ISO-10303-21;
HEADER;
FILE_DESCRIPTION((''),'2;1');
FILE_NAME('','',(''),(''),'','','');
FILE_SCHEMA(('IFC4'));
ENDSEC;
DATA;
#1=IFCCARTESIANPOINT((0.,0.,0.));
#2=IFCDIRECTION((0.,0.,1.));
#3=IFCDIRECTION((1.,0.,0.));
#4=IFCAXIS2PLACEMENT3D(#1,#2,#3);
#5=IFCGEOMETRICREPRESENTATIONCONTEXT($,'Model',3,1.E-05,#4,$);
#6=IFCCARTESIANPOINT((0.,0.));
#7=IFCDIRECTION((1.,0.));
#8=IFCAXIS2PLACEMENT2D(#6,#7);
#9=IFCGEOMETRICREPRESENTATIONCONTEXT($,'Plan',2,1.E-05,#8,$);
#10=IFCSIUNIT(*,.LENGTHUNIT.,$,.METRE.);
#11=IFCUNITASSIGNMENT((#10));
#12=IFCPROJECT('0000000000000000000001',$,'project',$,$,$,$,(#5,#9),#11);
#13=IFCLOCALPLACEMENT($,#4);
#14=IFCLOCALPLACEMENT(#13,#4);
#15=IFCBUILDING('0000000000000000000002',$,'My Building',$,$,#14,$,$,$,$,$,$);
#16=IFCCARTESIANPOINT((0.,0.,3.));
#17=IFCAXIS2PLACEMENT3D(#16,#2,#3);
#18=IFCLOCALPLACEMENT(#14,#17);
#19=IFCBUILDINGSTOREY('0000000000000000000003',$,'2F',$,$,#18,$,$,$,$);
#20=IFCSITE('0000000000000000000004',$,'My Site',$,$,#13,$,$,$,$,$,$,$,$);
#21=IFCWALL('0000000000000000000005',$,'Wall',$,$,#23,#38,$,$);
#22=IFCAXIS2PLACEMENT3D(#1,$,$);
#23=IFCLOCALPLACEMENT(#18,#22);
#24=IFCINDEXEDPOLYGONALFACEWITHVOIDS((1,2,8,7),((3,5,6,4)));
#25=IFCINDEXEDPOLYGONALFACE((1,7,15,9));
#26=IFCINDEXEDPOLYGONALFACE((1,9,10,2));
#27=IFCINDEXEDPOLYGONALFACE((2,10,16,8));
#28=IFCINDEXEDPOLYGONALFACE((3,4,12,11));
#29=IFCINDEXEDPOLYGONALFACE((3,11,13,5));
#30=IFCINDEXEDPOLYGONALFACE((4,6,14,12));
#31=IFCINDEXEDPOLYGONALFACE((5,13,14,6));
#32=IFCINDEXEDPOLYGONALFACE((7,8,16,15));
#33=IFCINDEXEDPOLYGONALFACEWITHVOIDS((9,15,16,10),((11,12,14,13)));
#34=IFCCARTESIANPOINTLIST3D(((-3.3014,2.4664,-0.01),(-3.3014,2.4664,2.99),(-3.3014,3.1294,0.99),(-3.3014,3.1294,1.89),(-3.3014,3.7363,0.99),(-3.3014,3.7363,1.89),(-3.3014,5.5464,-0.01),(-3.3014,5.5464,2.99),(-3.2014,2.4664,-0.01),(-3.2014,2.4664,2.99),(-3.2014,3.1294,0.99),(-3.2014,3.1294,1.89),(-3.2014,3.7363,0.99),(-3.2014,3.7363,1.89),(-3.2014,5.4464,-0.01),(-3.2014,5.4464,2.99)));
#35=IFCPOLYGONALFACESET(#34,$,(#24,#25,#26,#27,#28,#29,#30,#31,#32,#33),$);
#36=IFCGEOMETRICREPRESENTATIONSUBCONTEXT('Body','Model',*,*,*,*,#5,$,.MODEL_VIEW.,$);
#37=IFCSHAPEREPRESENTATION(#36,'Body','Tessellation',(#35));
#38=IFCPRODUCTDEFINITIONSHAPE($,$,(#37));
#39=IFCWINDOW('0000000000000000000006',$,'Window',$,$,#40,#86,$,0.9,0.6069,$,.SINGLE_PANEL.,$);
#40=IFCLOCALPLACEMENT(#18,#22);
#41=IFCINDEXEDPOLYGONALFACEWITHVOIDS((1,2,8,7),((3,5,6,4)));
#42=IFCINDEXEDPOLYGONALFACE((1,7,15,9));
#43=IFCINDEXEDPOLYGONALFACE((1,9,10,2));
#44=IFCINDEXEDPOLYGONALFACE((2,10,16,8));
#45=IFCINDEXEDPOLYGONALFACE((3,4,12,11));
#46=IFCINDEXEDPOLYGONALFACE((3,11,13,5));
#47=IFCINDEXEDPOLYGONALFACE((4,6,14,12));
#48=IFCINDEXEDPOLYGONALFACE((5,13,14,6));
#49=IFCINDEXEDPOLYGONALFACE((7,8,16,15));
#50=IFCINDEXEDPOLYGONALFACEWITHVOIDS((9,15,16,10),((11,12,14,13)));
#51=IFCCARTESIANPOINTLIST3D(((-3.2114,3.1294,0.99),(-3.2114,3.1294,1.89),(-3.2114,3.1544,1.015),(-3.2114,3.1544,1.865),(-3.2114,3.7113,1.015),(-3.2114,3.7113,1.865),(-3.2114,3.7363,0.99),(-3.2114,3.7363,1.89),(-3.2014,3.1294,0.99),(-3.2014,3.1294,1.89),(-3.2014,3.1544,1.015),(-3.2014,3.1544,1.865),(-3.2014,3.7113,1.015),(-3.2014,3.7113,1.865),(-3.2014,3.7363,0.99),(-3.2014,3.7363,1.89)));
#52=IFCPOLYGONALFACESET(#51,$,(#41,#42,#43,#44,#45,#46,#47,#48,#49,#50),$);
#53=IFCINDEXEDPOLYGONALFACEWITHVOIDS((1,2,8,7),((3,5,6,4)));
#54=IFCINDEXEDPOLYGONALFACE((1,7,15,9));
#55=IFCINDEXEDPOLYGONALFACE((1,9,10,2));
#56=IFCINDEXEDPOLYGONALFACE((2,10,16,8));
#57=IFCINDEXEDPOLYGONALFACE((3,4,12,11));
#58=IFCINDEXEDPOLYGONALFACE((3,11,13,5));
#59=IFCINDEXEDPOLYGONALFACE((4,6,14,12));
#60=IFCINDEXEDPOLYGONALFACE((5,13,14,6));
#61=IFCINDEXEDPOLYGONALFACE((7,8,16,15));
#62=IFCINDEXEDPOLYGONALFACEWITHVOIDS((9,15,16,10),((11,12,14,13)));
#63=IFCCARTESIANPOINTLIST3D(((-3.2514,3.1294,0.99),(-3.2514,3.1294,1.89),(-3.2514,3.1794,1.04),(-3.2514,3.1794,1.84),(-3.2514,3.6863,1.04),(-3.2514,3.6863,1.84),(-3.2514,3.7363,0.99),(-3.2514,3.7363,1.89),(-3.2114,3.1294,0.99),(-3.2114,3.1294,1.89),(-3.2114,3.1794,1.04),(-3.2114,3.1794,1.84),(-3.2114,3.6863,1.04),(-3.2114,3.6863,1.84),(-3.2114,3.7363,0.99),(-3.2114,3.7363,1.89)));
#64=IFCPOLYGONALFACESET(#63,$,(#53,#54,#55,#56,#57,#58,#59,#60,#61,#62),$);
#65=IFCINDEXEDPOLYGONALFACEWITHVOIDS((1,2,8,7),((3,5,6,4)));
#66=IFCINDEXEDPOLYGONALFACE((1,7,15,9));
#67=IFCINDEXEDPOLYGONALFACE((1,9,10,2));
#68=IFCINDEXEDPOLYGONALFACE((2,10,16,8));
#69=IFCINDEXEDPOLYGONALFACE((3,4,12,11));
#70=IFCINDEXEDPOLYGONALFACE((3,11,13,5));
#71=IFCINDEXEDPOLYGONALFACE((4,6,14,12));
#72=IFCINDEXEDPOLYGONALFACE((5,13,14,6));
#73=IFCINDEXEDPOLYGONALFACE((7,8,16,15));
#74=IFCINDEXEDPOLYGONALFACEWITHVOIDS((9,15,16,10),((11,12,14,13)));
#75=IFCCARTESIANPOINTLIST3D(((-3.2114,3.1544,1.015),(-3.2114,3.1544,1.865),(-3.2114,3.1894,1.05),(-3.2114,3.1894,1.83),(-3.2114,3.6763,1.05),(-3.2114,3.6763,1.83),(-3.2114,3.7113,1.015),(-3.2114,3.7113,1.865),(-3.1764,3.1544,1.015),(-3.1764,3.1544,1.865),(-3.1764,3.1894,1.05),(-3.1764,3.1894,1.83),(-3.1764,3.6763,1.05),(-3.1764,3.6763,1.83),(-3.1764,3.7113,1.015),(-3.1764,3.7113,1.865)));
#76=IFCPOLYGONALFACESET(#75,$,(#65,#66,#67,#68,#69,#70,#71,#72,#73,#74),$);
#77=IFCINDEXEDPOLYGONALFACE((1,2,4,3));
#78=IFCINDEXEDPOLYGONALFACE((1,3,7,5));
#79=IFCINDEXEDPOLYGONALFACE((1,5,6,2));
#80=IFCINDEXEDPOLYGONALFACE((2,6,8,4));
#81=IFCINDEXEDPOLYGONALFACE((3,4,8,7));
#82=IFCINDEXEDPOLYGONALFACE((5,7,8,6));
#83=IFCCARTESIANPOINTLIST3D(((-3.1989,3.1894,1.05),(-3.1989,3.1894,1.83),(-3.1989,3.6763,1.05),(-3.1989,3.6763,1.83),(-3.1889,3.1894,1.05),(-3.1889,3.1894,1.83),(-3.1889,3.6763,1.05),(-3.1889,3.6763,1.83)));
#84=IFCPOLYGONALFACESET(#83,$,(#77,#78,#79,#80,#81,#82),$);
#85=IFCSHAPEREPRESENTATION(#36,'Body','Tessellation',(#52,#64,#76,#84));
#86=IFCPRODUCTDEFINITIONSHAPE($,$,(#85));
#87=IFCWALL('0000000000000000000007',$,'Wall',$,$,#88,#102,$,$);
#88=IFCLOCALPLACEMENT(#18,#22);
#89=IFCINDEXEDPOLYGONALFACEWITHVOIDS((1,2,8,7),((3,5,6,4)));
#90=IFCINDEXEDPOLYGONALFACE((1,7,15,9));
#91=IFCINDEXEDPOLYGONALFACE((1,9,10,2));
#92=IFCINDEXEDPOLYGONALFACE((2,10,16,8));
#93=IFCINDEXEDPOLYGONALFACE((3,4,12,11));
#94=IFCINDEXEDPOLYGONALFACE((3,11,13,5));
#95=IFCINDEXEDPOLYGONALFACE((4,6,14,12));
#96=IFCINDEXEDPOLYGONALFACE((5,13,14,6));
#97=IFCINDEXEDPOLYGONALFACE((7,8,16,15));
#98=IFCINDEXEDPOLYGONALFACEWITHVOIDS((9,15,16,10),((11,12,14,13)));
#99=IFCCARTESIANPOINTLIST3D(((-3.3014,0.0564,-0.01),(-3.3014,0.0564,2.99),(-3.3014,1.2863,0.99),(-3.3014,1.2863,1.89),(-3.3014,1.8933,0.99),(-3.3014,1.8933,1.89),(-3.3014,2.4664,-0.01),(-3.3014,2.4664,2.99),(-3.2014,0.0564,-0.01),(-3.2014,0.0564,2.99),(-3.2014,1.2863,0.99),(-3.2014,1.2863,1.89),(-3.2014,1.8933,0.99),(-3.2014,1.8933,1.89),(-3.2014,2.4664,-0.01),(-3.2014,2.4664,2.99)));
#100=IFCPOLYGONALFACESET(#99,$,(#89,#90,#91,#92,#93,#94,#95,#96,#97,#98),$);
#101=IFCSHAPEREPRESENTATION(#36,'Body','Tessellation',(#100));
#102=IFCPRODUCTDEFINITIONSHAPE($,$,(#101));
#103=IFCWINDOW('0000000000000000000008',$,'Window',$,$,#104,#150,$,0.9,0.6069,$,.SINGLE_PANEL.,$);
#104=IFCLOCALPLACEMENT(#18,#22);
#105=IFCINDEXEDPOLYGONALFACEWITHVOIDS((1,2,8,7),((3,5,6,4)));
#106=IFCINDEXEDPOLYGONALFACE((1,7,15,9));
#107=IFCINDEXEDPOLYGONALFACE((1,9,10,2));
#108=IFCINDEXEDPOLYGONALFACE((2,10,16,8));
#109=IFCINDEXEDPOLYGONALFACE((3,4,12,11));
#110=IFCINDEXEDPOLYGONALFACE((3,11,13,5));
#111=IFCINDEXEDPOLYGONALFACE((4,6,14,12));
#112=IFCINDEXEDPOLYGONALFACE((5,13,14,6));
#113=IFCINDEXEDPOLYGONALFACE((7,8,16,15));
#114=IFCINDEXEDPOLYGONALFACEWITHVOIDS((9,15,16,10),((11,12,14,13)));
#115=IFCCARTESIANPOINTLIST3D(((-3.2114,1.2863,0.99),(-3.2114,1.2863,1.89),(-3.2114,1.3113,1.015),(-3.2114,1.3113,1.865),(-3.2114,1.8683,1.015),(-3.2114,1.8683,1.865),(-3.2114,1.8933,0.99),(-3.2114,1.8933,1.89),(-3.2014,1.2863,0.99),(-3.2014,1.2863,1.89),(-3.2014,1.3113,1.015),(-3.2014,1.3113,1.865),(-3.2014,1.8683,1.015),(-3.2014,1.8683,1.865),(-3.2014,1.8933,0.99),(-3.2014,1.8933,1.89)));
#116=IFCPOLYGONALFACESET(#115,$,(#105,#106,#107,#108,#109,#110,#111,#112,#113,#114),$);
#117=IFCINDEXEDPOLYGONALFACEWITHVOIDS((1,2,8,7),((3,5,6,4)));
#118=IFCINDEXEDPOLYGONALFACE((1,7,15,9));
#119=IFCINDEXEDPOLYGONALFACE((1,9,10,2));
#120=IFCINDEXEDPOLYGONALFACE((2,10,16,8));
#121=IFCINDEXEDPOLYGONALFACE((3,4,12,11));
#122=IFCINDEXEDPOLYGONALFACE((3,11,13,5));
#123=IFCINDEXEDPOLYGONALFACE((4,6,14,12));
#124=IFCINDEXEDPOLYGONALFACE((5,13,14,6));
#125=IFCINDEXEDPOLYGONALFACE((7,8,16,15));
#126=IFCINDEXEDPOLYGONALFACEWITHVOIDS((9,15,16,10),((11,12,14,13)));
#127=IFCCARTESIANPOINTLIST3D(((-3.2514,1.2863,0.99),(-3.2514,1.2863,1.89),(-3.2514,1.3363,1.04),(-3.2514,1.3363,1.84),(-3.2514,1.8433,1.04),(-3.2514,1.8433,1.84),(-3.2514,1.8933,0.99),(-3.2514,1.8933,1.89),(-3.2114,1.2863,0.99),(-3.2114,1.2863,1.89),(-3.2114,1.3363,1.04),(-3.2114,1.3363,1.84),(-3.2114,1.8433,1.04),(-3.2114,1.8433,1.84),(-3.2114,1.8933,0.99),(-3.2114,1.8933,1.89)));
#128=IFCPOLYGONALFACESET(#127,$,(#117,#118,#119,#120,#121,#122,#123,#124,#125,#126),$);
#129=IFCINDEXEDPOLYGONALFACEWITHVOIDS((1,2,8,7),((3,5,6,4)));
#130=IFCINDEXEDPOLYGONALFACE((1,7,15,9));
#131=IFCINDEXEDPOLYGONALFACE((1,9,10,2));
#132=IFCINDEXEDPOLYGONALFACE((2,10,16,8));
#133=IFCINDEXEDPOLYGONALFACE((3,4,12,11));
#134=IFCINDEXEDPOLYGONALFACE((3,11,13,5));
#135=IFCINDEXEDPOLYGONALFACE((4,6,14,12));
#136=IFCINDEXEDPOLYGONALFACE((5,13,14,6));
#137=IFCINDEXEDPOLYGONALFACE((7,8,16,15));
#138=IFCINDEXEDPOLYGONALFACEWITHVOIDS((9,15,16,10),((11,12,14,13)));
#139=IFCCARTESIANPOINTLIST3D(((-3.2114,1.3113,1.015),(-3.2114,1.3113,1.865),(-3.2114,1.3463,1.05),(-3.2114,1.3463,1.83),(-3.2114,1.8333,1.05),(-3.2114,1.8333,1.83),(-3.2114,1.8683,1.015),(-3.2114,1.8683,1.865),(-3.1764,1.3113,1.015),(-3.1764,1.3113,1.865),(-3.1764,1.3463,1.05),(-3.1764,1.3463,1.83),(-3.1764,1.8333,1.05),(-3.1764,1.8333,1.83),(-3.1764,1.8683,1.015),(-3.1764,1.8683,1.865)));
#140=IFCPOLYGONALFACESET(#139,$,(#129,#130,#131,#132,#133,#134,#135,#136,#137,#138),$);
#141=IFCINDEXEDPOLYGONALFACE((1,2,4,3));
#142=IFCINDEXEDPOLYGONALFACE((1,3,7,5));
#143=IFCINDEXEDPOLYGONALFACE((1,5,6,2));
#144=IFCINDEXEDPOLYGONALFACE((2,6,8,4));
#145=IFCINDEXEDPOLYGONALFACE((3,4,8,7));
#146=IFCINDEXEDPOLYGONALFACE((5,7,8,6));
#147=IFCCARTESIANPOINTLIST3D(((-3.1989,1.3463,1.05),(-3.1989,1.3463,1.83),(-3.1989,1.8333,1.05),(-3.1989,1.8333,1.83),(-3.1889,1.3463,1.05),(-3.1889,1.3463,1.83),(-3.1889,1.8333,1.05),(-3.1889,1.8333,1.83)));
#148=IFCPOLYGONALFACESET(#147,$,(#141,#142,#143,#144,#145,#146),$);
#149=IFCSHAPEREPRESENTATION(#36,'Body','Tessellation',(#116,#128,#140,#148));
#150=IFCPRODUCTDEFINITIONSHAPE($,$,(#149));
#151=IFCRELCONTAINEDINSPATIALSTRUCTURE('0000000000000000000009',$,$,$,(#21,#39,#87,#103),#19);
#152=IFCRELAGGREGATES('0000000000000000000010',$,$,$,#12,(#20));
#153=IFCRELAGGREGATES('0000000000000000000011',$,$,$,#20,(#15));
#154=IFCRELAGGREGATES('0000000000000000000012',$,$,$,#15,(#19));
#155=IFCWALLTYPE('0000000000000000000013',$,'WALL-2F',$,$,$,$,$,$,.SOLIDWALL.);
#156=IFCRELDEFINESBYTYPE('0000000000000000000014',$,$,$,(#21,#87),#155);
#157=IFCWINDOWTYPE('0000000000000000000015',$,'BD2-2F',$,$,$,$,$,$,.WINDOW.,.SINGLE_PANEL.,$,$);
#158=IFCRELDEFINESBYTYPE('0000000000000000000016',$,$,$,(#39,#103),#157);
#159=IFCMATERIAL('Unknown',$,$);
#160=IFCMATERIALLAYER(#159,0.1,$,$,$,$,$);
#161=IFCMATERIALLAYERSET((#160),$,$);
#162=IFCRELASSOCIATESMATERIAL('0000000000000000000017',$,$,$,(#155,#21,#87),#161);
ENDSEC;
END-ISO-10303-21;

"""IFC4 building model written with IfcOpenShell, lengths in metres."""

from ifc_helpers import new_model, entity, si_unit, frame, origin_with_axes, origin_2d_with_axis, place, context, subcontext, project, spatial, line, indexed_curve, outline, extrude, shape, source, transform, mapped, material, layer, layer_set, layer_usage, type_object, type_shapes, element, fill, save


model = new_model("IFC4")

# Units and contexts
model_context = context("Model", 3, precision=1e-05, world=origin_with_axes())
plan_context = context("Plan", 2, precision=1e-05, world=origin_2d_with_axis())
body_context_1 = subcontext(model_context, "Body", "Model", "MODEL_VIEW")
body_context_2 = subcontext(plan_context, "Body", "Plan", "PLAN_VIEW")
ifc_project = project(units=[si_unit("LENGTHUNIT", "METRE")], contexts=[model_context, plan_context])

# Site, building, storey
site_placement = place(None, origin_with_axes())
site = spatial("IfcSite", under=ifc_project, at=site_placement, Name="My Site")
building_placement = place(site_placement, origin_with_axes())
building = spatial("IfcBuilding", under=site, at=building_placement, Name="My Building")
storey_placement = place(building_placement, frame((0.0, 0.0, 3.0), z_axis=(0.0, 0.0, 1.0), x_axis=(1.0, 0.0, 0.0)))
storey = spatial("IfcBuildingStorey", under=building, at=storey_placement, Name="2F")

# Shared definitions
ifc_material_1 = material(Name="Unknown")

# Shared definitions
ifc_layer_1 = layer(ifc_material_1, 0.1)
ifc_layer_set_1 = layer_set([ifc_layer_1])
wall_type_1 = type_object("IfcWallType", Name="WALL-2F", PredefinedType="SOLIDWALL", material=ifc_layer_set_1)

# Walls, openings, windows
ifc_layer_usage_1 = layer_usage(ifc_layer_set_1, "AXIS2", "POSITIVE", 0.0)
wall_1_placement = place(storey_placement, frame((-3.3014, 5.5464, -0.01), z_axis=(0.0, 0.0, 1.0), x_axis=(0.0, -1.0, 0.0)))
wall_1 = element("IfcWall", 1, at=wall_1_placement, inside=storey, type_object=wall_type_1, material=ifc_layer_usage_1, Name="Wall", context=body_context_1, shape_type="SweptSolid", body=[
    extrude(outline(indexed_curve([(0.0, 0.0), (0.1, 0.1), (3.08, 0.1), (3.08, 0.0)], segments=[line(1, 2, 3, 4, 1)])), origin_with_axes(), (0.0, 0.0, 1.0), 3.0),
])
shared_shape_1 = source(origin_with_axes(), body_context_1, "Body", "SweptSolid", [
    extrude(outline(indexed_curve([(0.0, 0.0), (0.6069, 0.0), (0.6069, 0.9), (0.0, 0.9)], segments=[line(1, 2, 3, 4, 1)])), frame((0.0, -0.6, 0.0), z_axis=(0.0, -1.0, 0.0), x_axis=(1.0, 0.0, 0.0)), (0.0, 0.0, -1.0), 1.2),
])
opening_1_placement = place(wall_1_placement, frame((1.8101, 0.0, 1.0), z_axis=(0.0, 0.0, 1.0), x_axis=(1.0, 0.0, 0.0)))
opening_1 = element("IfcOpeningElement", 2, at=opening_1_placement, cuts=wall_1, PredefinedType="OPENING", context=body_context_1, shape_type="MappedRepresentation", body=[
    mapped(shared_shape_1, transform((0.0, 0.0, 0.0), x_axis=(1.0, 0.0, 0.0), y_axis=(0.0, 1.0, 0.0), z_axis=(0.0, 0.0, 1.0), scale=1.0)),
])
window_type_1 = type_object("IfcWindowType", Name="BD2-2F", PartitioningType="SINGLE_PANEL", PredefinedType="WINDOW")
shared_shape_2 = source(origin_with_axes(), body_context_1, "Body", "SweptSolid", [
    extrude(outline(indexed_curve([(0.0, 0.0), (0.6069, 0.0), (0.6069, 0.9), (0.0, 0.9)], segments=[line(1, 2, 3, 4, 1)]), holes=[indexed_curve([(0.025, 0.025), (0.5819, 0.025), (0.5819, 0.875), (0.025, 0.875)], segments=[line(1, 2, 3, 4, 1)])]), frame((0.0, 0.09, 0.0), z_axis=(0.0, -1.0, 0.0), x_axis=(1.0, 0.0, 0.0)), (0.0, 0.0, -1.0), 0.01),
    extrude(outline(indexed_curve([(0.0, 0.0), (0.6069, 0.0), (0.6069, 0.9), (0.0, 0.9)], segments=[line(1, 2, 3, 4, 1)]), holes=[indexed_curve([(0.05, 0.05), (0.5569, 0.05), (0.5569, 0.85), (0.05, 0.85)], segments=[line(1, 2, 3, 4, 1)])]), frame((0.0, 0.05, 0.0), z_axis=(0.0, -1.0, 0.0), x_axis=(1.0, 0.0, 0.0)), (0.0, 0.0, -1.0), 0.04),
    extrude(outline(indexed_curve([(0.0, 0.0), (0.5569, 0.0), (0.5569, 0.85), (0.0, 0.85)], segments=[line(1, 2, 3, 4, 1)]), holes=[indexed_curve([(0.035, 0.035), (0.5219, 0.035), (0.5219, 0.815), (0.035, 0.815)], segments=[line(1, 2, 3, 4, 1)])]), frame((0.025, 0.09, 0.025), z_axis=(0.0, -1.0, 0.0), x_axis=(1.0, 0.0, 0.0)), (0.0, 0.0, -1.0), 0.035),
    extrude(outline(indexed_curve([(0.035, 0.035), (0.5219, 0.035), (0.5219, 0.815), (0.035, 0.815)], segments=[line(1, 2, 3, 4, 1)])), frame((0.025, 0.1025, 0.025), z_axis=(0.0, -1.0, 0.0), x_axis=(1.0, 0.0, 0.0)), (0.0, 0.0, -1.0), 0.01),
])
shared_shape_3 = source(origin_with_axes(), body_context_2, "Body", "Curve2D", [
    entity("IfcIndexedPolyCurve", entity("IfcCartesianPointList2D", [[0.05, 0.05], [0.5569, 0.05]])),
    entity("IfcIndexedPolyCurve", entity("IfcCartesianPointList2D", [[0.0, 0.1], [0.025, 0.1], [0.025, 0.09], [0.05, 0.09], [0.05, 0.05], [0.0, 0.05]]), [entity("IfcLineIndex", [1, 2, 3, 4, 5, 6, 1])]),
    entity("IfcIndexedPolyCurve", entity("IfcCartesianPointList2D", [[0.6069, 0.1], [0.5819, 0.1], [0.5819, 0.09], [0.5569, 0.09], [0.5569, 0.05], [0.6069, 0.05]]), [entity("IfcLineIndex", [1, 2, 3, 4, 5, 6, 1])]),
    entity("IfcIndexedPolyCurve", entity("IfcCartesianPointList2D", [[0.025, 0.09], [0.06, 0.09], [0.06, 0.125], [0.025, 0.125]]), [entity("IfcLineIndex", [1, 2, 3, 4, 1])]),
    entity("IfcIndexedPolyCurve", entity("IfcCartesianPointList2D", [[0.5819, 0.09], [0.5469, 0.09], [0.5469, 0.125], [0.5819, 0.125]]), [entity("IfcLineIndex", [1, 2, 3, 4, 1])]),
    entity("IfcIndexedPolyCurve", entity("IfcCartesianPointList2D", [[0.06, 0.09], [0.5469, 0.09]])),
    entity("IfcIndexedPolyCurve", entity("IfcCartesianPointList2D", [[0.06, 0.125], [0.5469, 0.125]])),
    entity("IfcIndexedPolyCurve", entity("IfcCartesianPointList2D", [[0.06, 0.1075], [0.5469, 0.1075]])),
])
type_shapes(window_type_1, [shared_shape_2, shared_shape_3])
window_1_placement = place(opening_1_placement, frame((0.0, 0.0, 0.0), z_axis=(0.0, 0.0, 1.0), x_axis=(1.0, 0.0, 0.0)))
window_1 = element("IfcWindow", 3, at=window_1_placement, inside=storey, type_object=window_type_1, Name="Window", OverallHeight=0.9, OverallWidth=0.6069, PartitioningType="SINGLE_PANEL", shapes=[
    shape(body_context_1, "Body", "MappedRepresentation", [mapped(shared_shape_2, transform((0.0, 0.0, 0.0), x_axis=(1.0, 0.0, 0.0), y_axis=(0.0, 1.0, 0.0), z_axis=(0.0, 0.0, 1.0), scale=1.0))]),
    shape(body_context_2, "Body", "MappedRepresentation", [mapped(shared_shape_3, transform((0.0, 0.0, 0.0), x_axis=(1.0, 0.0, 0.0), y_axis=(0.0, 1.0, 0.0), z_axis=(0.0, 0.0, 1.0), scale=1.0))]),
])
fill(opening_1, window_1)
ifc_layer_usage_2 = layer_usage(ifc_layer_set_1, "AXIS2", "POSITIVE", 0.0)
wall_2_placement = place(storey_placement, frame((-3.3014, 2.4664, -0.01), z_axis=(0.0, 0.0, 1.0), x_axis=(0.0, -1.0, 0.0)))
wall_2 = element("IfcWall", 4, at=wall_2_placement, inside=storey, type_object=wall_type_1, material=ifc_layer_usage_2, Name="Wall", context=body_context_1, shape_type="SweptSolid", body=[
    extrude(outline(indexed_curve([(0.0, 0.0), (0.0, 0.1), (2.41, 0.1), (2.41, 0.0)], segments=[line(1, 2, 3, 4, 1)])), origin_with_axes(), (0.0, 0.0, 1.0), 3.0),
])
opening_2_placement = place(wall_2_placement, frame((0.5731, 0.0, 1.0), z_axis=(0.0, 0.0, 1.0), x_axis=(1.0, 0.0, 0.0)))
opening_2 = element("IfcOpeningElement", 5, at=opening_2_placement, cuts=wall_2, PredefinedType="OPENING", context=body_context_1, shape_type="MappedRepresentation", body=[
    mapped(shared_shape_1, transform((0.0, 0.0, 0.0), x_axis=(1.0, 0.0, 0.0), y_axis=(0.0, 1.0, 0.0), z_axis=(0.0, 0.0, 1.0), scale=1.0)),
])
window_2_placement = place(opening_2_placement, frame((0.0, 0.0, 0.0), z_axis=(0.0, 0.0, 1.0), x_axis=(1.0, 0.0, 0.0)))
window_2 = element("IfcWindow", 6, at=window_2_placement, inside=storey, type_object=window_type_1, Name="Window", OverallHeight=0.9, OverallWidth=0.6069, PartitioningType="SINGLE_PANEL", shapes=[
    shape(body_context_1, "Body", "MappedRepresentation", [mapped(shared_shape_2, transform((0.0, 0.0, 0.0), x_axis=(1.0, 0.0, 0.0), y_axis=(0.0, 1.0, 0.0), z_axis=(0.0, 0.0, 1.0), scale=1.0))]),
    shape(body_context_2, "Body", "MappedRepresentation", [mapped(shared_shape_3, transform((0.0, 0.0, 0.0), x_axis=(1.0, 0.0, 0.0), y_axis=(0.0, 1.0, 0.0), z_axis=(0.0, 0.0, 1.0), scale=1.0))]),
])
fill(opening_2, window_2)

save(model, "model.ifc")
